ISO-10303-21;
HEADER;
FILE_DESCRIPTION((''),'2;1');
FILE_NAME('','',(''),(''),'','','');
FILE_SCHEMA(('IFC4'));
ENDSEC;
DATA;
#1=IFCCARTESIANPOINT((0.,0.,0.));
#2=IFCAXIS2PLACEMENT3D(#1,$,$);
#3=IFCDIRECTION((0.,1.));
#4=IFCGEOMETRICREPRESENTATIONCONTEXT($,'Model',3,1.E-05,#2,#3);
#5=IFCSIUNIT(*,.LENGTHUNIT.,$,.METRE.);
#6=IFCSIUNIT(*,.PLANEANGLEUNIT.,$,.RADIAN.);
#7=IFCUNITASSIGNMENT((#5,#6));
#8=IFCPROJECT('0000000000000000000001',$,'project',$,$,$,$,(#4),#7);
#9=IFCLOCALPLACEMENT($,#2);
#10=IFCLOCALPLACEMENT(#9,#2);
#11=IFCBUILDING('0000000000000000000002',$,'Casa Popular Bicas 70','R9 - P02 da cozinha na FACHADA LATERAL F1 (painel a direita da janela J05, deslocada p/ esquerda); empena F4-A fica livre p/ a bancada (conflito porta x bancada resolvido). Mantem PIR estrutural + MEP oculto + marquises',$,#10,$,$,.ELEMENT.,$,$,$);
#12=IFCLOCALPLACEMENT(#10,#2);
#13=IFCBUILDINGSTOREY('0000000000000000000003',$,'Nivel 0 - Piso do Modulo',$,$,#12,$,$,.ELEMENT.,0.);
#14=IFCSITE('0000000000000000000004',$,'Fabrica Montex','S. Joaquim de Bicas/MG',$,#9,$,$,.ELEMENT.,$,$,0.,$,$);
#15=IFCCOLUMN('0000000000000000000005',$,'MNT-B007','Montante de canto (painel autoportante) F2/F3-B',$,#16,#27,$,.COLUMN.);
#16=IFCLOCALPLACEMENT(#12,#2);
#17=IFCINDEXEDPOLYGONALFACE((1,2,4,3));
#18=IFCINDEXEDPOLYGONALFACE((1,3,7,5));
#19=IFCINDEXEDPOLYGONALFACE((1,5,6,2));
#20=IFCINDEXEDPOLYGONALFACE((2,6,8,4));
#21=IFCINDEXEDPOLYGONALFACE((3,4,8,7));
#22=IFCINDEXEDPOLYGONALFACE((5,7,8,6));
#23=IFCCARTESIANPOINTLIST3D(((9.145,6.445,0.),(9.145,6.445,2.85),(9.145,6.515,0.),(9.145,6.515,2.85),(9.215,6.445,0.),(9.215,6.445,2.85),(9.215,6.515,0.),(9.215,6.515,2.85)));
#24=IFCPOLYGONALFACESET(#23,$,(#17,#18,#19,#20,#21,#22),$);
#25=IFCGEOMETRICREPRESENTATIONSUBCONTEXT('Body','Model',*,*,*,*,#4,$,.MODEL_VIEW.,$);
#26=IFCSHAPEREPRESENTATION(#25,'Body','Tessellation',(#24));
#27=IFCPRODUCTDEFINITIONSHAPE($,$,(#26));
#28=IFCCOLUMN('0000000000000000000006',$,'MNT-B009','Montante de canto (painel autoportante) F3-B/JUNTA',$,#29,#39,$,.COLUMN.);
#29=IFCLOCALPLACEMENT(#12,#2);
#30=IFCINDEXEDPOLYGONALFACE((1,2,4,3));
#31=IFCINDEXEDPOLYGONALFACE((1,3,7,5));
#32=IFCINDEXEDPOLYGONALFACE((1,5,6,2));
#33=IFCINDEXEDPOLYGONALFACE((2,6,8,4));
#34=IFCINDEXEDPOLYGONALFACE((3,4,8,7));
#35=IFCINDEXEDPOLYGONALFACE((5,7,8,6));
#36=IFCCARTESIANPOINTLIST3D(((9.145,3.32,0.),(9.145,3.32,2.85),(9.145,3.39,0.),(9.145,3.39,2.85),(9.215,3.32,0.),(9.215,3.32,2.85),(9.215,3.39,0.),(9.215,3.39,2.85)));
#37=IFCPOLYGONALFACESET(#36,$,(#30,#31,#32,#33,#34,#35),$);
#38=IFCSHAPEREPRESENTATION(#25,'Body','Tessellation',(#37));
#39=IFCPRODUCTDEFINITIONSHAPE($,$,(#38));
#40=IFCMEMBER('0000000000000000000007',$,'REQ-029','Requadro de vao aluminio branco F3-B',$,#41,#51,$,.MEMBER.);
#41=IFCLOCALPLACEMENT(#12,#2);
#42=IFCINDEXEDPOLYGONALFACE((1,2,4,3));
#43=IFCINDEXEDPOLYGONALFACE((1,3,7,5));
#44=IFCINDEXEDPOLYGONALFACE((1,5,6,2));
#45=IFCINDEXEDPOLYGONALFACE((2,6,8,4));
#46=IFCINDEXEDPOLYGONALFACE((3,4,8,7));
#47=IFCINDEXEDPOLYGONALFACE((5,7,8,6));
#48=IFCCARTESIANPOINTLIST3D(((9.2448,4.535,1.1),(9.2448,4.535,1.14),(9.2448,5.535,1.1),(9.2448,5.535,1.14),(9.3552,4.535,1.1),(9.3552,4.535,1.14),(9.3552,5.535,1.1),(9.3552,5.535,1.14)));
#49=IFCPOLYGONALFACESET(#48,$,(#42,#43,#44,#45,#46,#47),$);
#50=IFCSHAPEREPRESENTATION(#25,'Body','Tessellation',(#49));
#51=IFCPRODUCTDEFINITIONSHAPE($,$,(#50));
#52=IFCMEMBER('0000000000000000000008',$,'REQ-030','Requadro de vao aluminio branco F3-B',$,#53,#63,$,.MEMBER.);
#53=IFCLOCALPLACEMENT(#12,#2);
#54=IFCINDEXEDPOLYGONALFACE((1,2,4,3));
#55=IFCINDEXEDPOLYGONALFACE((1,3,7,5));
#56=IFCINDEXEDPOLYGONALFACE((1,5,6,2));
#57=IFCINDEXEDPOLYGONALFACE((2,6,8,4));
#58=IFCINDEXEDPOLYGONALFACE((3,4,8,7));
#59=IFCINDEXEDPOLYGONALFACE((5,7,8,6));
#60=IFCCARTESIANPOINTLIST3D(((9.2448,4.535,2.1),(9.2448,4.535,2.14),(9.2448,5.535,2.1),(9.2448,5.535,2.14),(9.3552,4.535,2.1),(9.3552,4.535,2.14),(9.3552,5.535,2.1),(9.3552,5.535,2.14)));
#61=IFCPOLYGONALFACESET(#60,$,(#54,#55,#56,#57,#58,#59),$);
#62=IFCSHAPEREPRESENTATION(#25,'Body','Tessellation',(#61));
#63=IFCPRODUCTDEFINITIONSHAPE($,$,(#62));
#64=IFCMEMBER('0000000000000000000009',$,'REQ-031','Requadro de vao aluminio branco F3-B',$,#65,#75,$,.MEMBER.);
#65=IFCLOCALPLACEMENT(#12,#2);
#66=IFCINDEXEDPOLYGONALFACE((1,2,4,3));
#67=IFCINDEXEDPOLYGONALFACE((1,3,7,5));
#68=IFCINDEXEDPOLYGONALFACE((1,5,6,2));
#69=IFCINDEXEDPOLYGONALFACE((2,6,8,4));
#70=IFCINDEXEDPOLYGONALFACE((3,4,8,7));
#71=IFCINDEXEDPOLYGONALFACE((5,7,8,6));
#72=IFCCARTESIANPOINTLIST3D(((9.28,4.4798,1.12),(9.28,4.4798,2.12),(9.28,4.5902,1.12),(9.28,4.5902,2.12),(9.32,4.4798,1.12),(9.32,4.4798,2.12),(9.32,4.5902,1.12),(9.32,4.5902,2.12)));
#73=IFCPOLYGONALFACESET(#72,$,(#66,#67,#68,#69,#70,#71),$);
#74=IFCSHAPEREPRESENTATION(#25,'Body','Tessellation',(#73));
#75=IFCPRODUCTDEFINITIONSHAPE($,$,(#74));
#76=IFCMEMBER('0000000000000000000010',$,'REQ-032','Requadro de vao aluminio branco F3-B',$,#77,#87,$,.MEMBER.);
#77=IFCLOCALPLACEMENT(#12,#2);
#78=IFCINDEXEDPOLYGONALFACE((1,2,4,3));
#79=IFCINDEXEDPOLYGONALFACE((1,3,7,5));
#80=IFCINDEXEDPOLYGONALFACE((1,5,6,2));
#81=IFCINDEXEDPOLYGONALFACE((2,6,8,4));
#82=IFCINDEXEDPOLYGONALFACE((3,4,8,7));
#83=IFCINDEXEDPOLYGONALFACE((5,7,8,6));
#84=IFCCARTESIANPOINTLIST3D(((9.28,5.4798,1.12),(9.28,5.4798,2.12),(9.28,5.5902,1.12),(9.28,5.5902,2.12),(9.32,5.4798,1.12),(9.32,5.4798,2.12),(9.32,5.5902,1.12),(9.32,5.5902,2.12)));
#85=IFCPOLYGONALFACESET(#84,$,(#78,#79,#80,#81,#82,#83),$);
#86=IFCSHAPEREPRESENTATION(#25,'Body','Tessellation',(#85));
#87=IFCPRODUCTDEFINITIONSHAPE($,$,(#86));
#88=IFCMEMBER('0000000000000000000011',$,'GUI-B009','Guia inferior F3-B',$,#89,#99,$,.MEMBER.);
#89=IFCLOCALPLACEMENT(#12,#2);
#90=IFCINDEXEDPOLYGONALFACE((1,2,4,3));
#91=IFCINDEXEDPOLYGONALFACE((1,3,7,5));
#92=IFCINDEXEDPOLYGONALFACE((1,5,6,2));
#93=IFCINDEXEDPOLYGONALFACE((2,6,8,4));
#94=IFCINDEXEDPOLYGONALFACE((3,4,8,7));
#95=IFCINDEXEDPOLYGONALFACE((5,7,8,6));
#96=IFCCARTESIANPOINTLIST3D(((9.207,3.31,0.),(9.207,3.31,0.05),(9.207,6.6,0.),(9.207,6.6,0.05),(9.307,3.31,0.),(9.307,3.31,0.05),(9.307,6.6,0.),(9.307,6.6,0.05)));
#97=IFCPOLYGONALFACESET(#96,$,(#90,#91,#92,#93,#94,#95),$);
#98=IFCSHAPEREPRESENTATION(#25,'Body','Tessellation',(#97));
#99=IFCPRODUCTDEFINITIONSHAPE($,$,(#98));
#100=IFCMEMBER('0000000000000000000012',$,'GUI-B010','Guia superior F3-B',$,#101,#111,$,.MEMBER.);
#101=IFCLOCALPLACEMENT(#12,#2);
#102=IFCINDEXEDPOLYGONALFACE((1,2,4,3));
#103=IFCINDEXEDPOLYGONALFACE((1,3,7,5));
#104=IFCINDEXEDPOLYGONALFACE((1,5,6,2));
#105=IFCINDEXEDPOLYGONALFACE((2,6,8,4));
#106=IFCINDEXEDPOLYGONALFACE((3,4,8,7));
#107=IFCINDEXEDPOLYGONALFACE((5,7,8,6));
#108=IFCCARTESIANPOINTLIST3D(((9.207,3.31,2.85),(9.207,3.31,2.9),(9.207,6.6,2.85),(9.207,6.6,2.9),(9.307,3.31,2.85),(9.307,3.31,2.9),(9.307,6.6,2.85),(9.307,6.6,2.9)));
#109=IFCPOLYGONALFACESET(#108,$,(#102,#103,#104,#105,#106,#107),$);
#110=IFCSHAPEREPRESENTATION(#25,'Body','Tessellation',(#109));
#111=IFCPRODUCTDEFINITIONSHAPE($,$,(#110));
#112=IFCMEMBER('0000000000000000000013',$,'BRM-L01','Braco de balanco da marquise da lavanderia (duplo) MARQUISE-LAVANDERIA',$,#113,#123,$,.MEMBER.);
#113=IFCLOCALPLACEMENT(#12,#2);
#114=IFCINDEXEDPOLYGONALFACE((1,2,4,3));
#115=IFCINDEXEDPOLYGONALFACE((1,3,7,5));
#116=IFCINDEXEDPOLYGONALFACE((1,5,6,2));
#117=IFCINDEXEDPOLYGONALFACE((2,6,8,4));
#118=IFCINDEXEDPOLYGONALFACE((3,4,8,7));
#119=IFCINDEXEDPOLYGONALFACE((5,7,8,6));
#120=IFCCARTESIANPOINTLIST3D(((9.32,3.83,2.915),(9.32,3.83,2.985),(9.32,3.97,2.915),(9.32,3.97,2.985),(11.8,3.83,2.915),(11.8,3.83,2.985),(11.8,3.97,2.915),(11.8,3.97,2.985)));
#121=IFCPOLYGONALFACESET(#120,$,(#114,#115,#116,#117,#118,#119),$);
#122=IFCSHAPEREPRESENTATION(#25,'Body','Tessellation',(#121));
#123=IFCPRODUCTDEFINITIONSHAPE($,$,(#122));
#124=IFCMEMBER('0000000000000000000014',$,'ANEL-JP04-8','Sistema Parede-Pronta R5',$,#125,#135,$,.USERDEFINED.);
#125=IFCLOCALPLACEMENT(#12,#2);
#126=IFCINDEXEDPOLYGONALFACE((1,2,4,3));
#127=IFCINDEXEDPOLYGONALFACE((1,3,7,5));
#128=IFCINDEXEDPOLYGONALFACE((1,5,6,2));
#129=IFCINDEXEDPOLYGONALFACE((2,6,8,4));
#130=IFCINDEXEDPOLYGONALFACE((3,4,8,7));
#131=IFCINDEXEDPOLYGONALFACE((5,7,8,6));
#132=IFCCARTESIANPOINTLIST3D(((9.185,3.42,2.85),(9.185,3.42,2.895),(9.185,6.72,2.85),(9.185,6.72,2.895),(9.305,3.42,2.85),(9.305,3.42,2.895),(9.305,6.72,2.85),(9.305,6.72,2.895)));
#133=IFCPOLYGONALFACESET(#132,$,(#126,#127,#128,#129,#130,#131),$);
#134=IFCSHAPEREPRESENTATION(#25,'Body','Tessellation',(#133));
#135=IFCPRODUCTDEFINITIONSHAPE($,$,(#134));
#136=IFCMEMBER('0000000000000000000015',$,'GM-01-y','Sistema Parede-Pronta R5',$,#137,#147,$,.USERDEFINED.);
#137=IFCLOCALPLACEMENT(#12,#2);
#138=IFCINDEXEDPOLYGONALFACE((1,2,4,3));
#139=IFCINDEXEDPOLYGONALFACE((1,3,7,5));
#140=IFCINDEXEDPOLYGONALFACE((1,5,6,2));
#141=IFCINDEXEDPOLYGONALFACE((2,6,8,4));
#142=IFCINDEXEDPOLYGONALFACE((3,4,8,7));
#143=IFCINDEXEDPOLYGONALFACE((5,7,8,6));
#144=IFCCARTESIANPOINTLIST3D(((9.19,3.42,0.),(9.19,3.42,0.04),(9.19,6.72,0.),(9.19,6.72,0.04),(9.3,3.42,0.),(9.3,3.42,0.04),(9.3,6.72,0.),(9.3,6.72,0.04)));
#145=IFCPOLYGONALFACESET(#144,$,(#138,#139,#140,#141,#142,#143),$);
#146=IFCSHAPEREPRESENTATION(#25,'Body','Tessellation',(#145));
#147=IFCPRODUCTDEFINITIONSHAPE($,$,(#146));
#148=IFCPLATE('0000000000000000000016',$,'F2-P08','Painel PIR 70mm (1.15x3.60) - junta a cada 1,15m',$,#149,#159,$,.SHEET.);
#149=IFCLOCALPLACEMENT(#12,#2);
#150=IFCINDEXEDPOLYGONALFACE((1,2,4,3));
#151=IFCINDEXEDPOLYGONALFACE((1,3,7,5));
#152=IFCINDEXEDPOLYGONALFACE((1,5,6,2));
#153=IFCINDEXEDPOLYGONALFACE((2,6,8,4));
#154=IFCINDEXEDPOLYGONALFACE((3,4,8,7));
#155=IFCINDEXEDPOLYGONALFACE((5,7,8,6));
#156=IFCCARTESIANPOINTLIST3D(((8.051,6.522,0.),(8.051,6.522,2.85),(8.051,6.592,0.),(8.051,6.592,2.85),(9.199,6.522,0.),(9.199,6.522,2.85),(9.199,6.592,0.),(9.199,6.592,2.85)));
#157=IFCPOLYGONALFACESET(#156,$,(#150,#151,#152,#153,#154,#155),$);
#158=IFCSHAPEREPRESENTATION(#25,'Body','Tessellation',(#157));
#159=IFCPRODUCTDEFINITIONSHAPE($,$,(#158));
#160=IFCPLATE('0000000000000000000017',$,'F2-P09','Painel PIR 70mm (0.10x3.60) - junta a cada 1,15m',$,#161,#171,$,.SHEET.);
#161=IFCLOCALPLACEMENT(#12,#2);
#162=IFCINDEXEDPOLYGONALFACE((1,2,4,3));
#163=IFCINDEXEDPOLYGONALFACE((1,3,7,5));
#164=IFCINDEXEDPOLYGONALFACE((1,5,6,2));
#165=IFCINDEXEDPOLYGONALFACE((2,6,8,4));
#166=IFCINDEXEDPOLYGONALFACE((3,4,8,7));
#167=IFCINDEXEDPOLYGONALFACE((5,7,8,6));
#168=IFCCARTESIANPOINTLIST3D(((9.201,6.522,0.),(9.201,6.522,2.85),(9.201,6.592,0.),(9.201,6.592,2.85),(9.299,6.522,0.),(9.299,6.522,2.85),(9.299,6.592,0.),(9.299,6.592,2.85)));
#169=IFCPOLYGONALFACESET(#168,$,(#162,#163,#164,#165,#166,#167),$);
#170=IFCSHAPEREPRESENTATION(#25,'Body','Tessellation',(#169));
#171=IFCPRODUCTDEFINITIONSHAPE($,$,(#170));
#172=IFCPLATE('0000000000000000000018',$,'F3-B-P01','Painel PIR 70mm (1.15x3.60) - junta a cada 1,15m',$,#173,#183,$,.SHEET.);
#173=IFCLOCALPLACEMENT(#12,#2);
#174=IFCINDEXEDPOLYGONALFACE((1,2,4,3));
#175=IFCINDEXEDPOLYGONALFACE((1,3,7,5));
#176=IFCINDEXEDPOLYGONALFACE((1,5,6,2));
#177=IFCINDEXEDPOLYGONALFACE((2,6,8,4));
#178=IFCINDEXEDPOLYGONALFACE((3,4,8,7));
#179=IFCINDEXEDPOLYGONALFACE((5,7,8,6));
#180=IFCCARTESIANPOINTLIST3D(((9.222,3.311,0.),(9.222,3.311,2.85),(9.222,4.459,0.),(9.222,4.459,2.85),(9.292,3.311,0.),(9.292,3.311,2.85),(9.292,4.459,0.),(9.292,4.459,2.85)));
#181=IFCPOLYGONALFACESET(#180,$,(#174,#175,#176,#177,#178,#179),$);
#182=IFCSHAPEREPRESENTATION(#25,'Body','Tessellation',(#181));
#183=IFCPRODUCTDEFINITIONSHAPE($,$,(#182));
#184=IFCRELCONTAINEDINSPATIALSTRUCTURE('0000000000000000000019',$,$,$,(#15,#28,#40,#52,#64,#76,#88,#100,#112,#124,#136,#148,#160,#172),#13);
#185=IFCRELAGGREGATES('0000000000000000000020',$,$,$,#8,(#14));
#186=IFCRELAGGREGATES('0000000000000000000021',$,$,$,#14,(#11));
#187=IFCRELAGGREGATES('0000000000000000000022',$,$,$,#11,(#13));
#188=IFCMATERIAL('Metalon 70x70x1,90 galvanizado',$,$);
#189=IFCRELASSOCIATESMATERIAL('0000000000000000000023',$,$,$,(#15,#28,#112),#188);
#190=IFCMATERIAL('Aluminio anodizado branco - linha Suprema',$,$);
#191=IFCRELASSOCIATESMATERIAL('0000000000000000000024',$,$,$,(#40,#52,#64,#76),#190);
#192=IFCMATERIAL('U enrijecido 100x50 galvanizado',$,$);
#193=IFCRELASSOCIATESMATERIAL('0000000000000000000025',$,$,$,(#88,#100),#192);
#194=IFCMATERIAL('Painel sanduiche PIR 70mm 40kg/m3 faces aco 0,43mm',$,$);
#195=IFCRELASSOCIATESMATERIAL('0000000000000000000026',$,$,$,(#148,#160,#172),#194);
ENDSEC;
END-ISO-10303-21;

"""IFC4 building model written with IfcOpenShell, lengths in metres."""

from ifc_helpers import new_model, si_unit, direction, frame, frame_2d, origin, origin_2d, place, context, subcontext, project, spatial, rectangle, extrude, material, element, save


model = new_model("IFC4")

# Units and contexts
model_context = context("Model", 3, precision=1e-05, world=origin(), true_north=direction((0.0, 1.0)))
body_context = subcontext(model_context, "Body", "Model", "MODEL_VIEW")
ifc_project = project(units=[si_unit("LENGTHUNIT", "METRE"), si_unit("PLANEANGLEUNIT", "RADIAN")], contexts=[model_context])

# Site, building, storey
site_placement = place(None, origin())
site = spatial("IfcSite", under=ifc_project, at=site_placement, Name="Fabrica Montex", Description="S. Joaquim de Bicas/MG", CompositionType="ELEMENT", RefElevation=0.0)
building_placement = place(site_placement, origin())
building = spatial("IfcBuilding", under=site, at=building_placement, Name="Casa Popular Bicas 70", Description="R9 - P02 da cozinha na FACHADA LATERAL F1 (painel a direita da janela J05, deslocada p/ esquerda); empena F4-A fica livre p/ a bancada (conflito porta x bancada resolvido). Mantem PIR estrutural + MEP oculto + marquises", CompositionType="ELEMENT")
storey_placement = place(building_placement, origin())
storey = spatial("IfcBuildingStorey", under=building, at=storey_placement, Name="Nivel 0 - Piso do Modulo", CompositionType="ELEMENT", Elevation=0.0)

# Columns
ifc_material_1 = material(Name="Metalon 70x70x1,90 galvanizado")
for number, where, name, description in (
    (1, (9.18, 6.48, 0.0), "MNT-B007", "Montante de canto (painel autoportante) F2/F3-B"),
    (2, (9.18, 3.355, 0.0), "MNT-B009", "Montante de canto (painel autoportante) F3-B/JUNTA"),
):
    element("IfcColumn", number, at=place(storey_placement, frame(where)), inside=storey, material=ifc_material_1, Name=name, Description=description, PredefinedType="COLUMN", context=body_context, shape_type="SweptSolid", body=[
        extrude(rectangle(XDim=0.07, YDim=0.07, at=origin_2d()), origin(), (0.0, 0.0, 1.0), 2.85),
    ])

# Members
ifc_material_2 = material(Name="Aluminio anodizado branco - linha Suprema")
for number, where, z_axis, x_axis, name in (
    (3, (9.3, 4.535, 1.12), (0.0, 1.0, 0.0), (0.0, 0.0, 1.0), "REQ-029"),
    (4, (9.3, 4.535, 2.12), (0.0, 1.0, 0.0), (0.0, 0.0, 1.0), "REQ-030"),
    (5, (9.3, 4.535, 1.12), (0.0, 0.0, 1.0), (1.0, 0.0, 0.0), "REQ-031"),
    (6, (9.3, 5.535, 1.12), (0.0, 0.0, 1.0), (1.0, 0.0, 0.0), "REQ-032"),
):
    element("IfcMember", number, at=place(storey_placement, frame(where, z_axis=z_axis, x_axis=x_axis)), inside=storey, material=ifc_material_2, Name=name, Description="Requadro de vao aluminio branco F3-B", PredefinedType="MEMBER", context=body_context, shape_type="SweptSolid", body=[
        extrude(rectangle(XDim=0.04, YDim=0.1105, at=origin_2d()), origin(), (0.0, 0.0, 1.0), 1.0),
    ])
ifc_material_3 = material(Name="U enrijecido 100x50 galvanizado")
for number, where, z_axis, x_axis, name, description in (
    (7, (9.257, 3.31, 0.025), (0.0, 1.0, 0.0), (0.0, 0.0, 1.0), "GUI-B009", "Guia inferior F3-B"),
    (8, (9.257, 3.31, 2.875), (0.0, 1.0, 0.0), (0.0, 0.0, 1.0), "GUI-B010", "Guia superior F3-B"),
):
    element("IfcMember", number, at=place(storey_placement, frame(where, z_axis=z_axis, x_axis=x_axis)), inside=storey, material=ifc_material_3, Name=name, Description=description, PredefinedType="MEMBER", context=body_context, shape_type="SweptSolid", body=[
        extrude(rectangle(XDim=0.05, YDim=0.1, at=origin_2d()), origin(), (0.0, 0.0, 1.0), 3.29),
    ])
member_1_placement = place(storey_placement, frame((9.32, 3.9, 2.95), z_axis=(1.0, 0.0, 0.0), x_axis=(0.0, 0.0, 1.0)))
element("IfcMember", 9, at=member_1_placement, inside=storey, material=ifc_material_1, Name="BRM-L01", Description="Braco de balanco da marquise da lavanderia (duplo) MARQUISE-LAVANDERIA", PredefinedType="MEMBER", context=body_context, shape_type="SweptSolid", body=[
    extrude(rectangle(XDim=0.07, YDim=0.14, at=origin_2d()), origin(), (0.0, 0.0, 1.0), 2.48),
])
member_2_placement = place(storey_placement, frame((9.245, 5.07, 2.85)))
element("IfcMember", 10, at=member_2_placement, inside=storey, Name="ANEL-JP04-8", Description="Sistema Parede-Pronta R5", PredefinedType="USERDEFINED", context=body_context, shape_type="SweptSolid", body=[
    extrude(rectangle(XDim=0.12, YDim=3.3, at=origin_2d()), origin(), (0.0, 0.0, 1.0), 0.045),
])
member_3_placement = place(storey_placement, frame((9.245, 5.07, 0.0)))
element("IfcMember", 11, at=member_3_placement, inside=storey, Name="GM-01-y", Description="Sistema Parede-Pronta R5", PredefinedType="USERDEFINED", context=body_context, shape_type="SweptSolid", body=[
    extrude(rectangle(XDim=0.11, YDim=3.3, at=origin_2d()), origin(), (0.0, 0.0, 1.0), 0.04),
])

# Plates
ifc_material_4 = material(Name="Painel sanduiche PIR 70mm 40kg/m3 faces aco 0,43mm")
plate_1_placement = place(storey_placement, frame((8.051, 6.557, 0.0), x_axis=(1.0, 0.0, 0.0)))
element("IfcPlate", 12, at=plate_1_placement, inside=storey, material=ifc_material_4, Name="F2-P08", Description="Painel PIR 70mm (1.15x3.60) - junta a cada 1,15m", PredefinedType="SHEET", context=body_context, shape_type="SweptSolid", body=[
    extrude(rectangle(XDim=1.148, YDim=0.07, at=frame_2d((0.574, 0.0))), origin(), (0.0, 0.0, 1.0), 2.85),
])
plate_2_placement = place(storey_placement, frame((9.201, 6.557, 0.0), x_axis=(1.0, 0.0, 0.0)))
element("IfcPlate", 13, at=plate_2_placement, inside=storey, material=ifc_material_4, Name="F2-P09", Description="Painel PIR 70mm (0.10x3.60) - junta a cada 1,15m", PredefinedType="SHEET", context=body_context, shape_type="SweptSolid", body=[
    extrude(rectangle(XDim=0.098, YDim=0.07, at=frame_2d((0.049, 0.0))), origin(), (0.0, 0.0, 1.0), 2.85),
])
plate_3_placement = place(storey_placement, frame((9.257, 3.311, 0.0), x_axis=(0.0, 1.0, 0.0)))
element("IfcPlate", 14, at=plate_3_placement, inside=storey, material=ifc_material_4, Name="F3-B-P01", Description="Painel PIR 70mm (1.15x3.60) - junta a cada 1,15m", PredefinedType="SHEET", context=body_context, shape_type="SweptSolid", body=[
    extrude(rectangle(XDim=1.148, YDim=0.07, at=frame_2d((0.574, 0.0))), origin(), (0.0, 0.0, 1.0), 2.85),
])

save(model, "model.ifc")
